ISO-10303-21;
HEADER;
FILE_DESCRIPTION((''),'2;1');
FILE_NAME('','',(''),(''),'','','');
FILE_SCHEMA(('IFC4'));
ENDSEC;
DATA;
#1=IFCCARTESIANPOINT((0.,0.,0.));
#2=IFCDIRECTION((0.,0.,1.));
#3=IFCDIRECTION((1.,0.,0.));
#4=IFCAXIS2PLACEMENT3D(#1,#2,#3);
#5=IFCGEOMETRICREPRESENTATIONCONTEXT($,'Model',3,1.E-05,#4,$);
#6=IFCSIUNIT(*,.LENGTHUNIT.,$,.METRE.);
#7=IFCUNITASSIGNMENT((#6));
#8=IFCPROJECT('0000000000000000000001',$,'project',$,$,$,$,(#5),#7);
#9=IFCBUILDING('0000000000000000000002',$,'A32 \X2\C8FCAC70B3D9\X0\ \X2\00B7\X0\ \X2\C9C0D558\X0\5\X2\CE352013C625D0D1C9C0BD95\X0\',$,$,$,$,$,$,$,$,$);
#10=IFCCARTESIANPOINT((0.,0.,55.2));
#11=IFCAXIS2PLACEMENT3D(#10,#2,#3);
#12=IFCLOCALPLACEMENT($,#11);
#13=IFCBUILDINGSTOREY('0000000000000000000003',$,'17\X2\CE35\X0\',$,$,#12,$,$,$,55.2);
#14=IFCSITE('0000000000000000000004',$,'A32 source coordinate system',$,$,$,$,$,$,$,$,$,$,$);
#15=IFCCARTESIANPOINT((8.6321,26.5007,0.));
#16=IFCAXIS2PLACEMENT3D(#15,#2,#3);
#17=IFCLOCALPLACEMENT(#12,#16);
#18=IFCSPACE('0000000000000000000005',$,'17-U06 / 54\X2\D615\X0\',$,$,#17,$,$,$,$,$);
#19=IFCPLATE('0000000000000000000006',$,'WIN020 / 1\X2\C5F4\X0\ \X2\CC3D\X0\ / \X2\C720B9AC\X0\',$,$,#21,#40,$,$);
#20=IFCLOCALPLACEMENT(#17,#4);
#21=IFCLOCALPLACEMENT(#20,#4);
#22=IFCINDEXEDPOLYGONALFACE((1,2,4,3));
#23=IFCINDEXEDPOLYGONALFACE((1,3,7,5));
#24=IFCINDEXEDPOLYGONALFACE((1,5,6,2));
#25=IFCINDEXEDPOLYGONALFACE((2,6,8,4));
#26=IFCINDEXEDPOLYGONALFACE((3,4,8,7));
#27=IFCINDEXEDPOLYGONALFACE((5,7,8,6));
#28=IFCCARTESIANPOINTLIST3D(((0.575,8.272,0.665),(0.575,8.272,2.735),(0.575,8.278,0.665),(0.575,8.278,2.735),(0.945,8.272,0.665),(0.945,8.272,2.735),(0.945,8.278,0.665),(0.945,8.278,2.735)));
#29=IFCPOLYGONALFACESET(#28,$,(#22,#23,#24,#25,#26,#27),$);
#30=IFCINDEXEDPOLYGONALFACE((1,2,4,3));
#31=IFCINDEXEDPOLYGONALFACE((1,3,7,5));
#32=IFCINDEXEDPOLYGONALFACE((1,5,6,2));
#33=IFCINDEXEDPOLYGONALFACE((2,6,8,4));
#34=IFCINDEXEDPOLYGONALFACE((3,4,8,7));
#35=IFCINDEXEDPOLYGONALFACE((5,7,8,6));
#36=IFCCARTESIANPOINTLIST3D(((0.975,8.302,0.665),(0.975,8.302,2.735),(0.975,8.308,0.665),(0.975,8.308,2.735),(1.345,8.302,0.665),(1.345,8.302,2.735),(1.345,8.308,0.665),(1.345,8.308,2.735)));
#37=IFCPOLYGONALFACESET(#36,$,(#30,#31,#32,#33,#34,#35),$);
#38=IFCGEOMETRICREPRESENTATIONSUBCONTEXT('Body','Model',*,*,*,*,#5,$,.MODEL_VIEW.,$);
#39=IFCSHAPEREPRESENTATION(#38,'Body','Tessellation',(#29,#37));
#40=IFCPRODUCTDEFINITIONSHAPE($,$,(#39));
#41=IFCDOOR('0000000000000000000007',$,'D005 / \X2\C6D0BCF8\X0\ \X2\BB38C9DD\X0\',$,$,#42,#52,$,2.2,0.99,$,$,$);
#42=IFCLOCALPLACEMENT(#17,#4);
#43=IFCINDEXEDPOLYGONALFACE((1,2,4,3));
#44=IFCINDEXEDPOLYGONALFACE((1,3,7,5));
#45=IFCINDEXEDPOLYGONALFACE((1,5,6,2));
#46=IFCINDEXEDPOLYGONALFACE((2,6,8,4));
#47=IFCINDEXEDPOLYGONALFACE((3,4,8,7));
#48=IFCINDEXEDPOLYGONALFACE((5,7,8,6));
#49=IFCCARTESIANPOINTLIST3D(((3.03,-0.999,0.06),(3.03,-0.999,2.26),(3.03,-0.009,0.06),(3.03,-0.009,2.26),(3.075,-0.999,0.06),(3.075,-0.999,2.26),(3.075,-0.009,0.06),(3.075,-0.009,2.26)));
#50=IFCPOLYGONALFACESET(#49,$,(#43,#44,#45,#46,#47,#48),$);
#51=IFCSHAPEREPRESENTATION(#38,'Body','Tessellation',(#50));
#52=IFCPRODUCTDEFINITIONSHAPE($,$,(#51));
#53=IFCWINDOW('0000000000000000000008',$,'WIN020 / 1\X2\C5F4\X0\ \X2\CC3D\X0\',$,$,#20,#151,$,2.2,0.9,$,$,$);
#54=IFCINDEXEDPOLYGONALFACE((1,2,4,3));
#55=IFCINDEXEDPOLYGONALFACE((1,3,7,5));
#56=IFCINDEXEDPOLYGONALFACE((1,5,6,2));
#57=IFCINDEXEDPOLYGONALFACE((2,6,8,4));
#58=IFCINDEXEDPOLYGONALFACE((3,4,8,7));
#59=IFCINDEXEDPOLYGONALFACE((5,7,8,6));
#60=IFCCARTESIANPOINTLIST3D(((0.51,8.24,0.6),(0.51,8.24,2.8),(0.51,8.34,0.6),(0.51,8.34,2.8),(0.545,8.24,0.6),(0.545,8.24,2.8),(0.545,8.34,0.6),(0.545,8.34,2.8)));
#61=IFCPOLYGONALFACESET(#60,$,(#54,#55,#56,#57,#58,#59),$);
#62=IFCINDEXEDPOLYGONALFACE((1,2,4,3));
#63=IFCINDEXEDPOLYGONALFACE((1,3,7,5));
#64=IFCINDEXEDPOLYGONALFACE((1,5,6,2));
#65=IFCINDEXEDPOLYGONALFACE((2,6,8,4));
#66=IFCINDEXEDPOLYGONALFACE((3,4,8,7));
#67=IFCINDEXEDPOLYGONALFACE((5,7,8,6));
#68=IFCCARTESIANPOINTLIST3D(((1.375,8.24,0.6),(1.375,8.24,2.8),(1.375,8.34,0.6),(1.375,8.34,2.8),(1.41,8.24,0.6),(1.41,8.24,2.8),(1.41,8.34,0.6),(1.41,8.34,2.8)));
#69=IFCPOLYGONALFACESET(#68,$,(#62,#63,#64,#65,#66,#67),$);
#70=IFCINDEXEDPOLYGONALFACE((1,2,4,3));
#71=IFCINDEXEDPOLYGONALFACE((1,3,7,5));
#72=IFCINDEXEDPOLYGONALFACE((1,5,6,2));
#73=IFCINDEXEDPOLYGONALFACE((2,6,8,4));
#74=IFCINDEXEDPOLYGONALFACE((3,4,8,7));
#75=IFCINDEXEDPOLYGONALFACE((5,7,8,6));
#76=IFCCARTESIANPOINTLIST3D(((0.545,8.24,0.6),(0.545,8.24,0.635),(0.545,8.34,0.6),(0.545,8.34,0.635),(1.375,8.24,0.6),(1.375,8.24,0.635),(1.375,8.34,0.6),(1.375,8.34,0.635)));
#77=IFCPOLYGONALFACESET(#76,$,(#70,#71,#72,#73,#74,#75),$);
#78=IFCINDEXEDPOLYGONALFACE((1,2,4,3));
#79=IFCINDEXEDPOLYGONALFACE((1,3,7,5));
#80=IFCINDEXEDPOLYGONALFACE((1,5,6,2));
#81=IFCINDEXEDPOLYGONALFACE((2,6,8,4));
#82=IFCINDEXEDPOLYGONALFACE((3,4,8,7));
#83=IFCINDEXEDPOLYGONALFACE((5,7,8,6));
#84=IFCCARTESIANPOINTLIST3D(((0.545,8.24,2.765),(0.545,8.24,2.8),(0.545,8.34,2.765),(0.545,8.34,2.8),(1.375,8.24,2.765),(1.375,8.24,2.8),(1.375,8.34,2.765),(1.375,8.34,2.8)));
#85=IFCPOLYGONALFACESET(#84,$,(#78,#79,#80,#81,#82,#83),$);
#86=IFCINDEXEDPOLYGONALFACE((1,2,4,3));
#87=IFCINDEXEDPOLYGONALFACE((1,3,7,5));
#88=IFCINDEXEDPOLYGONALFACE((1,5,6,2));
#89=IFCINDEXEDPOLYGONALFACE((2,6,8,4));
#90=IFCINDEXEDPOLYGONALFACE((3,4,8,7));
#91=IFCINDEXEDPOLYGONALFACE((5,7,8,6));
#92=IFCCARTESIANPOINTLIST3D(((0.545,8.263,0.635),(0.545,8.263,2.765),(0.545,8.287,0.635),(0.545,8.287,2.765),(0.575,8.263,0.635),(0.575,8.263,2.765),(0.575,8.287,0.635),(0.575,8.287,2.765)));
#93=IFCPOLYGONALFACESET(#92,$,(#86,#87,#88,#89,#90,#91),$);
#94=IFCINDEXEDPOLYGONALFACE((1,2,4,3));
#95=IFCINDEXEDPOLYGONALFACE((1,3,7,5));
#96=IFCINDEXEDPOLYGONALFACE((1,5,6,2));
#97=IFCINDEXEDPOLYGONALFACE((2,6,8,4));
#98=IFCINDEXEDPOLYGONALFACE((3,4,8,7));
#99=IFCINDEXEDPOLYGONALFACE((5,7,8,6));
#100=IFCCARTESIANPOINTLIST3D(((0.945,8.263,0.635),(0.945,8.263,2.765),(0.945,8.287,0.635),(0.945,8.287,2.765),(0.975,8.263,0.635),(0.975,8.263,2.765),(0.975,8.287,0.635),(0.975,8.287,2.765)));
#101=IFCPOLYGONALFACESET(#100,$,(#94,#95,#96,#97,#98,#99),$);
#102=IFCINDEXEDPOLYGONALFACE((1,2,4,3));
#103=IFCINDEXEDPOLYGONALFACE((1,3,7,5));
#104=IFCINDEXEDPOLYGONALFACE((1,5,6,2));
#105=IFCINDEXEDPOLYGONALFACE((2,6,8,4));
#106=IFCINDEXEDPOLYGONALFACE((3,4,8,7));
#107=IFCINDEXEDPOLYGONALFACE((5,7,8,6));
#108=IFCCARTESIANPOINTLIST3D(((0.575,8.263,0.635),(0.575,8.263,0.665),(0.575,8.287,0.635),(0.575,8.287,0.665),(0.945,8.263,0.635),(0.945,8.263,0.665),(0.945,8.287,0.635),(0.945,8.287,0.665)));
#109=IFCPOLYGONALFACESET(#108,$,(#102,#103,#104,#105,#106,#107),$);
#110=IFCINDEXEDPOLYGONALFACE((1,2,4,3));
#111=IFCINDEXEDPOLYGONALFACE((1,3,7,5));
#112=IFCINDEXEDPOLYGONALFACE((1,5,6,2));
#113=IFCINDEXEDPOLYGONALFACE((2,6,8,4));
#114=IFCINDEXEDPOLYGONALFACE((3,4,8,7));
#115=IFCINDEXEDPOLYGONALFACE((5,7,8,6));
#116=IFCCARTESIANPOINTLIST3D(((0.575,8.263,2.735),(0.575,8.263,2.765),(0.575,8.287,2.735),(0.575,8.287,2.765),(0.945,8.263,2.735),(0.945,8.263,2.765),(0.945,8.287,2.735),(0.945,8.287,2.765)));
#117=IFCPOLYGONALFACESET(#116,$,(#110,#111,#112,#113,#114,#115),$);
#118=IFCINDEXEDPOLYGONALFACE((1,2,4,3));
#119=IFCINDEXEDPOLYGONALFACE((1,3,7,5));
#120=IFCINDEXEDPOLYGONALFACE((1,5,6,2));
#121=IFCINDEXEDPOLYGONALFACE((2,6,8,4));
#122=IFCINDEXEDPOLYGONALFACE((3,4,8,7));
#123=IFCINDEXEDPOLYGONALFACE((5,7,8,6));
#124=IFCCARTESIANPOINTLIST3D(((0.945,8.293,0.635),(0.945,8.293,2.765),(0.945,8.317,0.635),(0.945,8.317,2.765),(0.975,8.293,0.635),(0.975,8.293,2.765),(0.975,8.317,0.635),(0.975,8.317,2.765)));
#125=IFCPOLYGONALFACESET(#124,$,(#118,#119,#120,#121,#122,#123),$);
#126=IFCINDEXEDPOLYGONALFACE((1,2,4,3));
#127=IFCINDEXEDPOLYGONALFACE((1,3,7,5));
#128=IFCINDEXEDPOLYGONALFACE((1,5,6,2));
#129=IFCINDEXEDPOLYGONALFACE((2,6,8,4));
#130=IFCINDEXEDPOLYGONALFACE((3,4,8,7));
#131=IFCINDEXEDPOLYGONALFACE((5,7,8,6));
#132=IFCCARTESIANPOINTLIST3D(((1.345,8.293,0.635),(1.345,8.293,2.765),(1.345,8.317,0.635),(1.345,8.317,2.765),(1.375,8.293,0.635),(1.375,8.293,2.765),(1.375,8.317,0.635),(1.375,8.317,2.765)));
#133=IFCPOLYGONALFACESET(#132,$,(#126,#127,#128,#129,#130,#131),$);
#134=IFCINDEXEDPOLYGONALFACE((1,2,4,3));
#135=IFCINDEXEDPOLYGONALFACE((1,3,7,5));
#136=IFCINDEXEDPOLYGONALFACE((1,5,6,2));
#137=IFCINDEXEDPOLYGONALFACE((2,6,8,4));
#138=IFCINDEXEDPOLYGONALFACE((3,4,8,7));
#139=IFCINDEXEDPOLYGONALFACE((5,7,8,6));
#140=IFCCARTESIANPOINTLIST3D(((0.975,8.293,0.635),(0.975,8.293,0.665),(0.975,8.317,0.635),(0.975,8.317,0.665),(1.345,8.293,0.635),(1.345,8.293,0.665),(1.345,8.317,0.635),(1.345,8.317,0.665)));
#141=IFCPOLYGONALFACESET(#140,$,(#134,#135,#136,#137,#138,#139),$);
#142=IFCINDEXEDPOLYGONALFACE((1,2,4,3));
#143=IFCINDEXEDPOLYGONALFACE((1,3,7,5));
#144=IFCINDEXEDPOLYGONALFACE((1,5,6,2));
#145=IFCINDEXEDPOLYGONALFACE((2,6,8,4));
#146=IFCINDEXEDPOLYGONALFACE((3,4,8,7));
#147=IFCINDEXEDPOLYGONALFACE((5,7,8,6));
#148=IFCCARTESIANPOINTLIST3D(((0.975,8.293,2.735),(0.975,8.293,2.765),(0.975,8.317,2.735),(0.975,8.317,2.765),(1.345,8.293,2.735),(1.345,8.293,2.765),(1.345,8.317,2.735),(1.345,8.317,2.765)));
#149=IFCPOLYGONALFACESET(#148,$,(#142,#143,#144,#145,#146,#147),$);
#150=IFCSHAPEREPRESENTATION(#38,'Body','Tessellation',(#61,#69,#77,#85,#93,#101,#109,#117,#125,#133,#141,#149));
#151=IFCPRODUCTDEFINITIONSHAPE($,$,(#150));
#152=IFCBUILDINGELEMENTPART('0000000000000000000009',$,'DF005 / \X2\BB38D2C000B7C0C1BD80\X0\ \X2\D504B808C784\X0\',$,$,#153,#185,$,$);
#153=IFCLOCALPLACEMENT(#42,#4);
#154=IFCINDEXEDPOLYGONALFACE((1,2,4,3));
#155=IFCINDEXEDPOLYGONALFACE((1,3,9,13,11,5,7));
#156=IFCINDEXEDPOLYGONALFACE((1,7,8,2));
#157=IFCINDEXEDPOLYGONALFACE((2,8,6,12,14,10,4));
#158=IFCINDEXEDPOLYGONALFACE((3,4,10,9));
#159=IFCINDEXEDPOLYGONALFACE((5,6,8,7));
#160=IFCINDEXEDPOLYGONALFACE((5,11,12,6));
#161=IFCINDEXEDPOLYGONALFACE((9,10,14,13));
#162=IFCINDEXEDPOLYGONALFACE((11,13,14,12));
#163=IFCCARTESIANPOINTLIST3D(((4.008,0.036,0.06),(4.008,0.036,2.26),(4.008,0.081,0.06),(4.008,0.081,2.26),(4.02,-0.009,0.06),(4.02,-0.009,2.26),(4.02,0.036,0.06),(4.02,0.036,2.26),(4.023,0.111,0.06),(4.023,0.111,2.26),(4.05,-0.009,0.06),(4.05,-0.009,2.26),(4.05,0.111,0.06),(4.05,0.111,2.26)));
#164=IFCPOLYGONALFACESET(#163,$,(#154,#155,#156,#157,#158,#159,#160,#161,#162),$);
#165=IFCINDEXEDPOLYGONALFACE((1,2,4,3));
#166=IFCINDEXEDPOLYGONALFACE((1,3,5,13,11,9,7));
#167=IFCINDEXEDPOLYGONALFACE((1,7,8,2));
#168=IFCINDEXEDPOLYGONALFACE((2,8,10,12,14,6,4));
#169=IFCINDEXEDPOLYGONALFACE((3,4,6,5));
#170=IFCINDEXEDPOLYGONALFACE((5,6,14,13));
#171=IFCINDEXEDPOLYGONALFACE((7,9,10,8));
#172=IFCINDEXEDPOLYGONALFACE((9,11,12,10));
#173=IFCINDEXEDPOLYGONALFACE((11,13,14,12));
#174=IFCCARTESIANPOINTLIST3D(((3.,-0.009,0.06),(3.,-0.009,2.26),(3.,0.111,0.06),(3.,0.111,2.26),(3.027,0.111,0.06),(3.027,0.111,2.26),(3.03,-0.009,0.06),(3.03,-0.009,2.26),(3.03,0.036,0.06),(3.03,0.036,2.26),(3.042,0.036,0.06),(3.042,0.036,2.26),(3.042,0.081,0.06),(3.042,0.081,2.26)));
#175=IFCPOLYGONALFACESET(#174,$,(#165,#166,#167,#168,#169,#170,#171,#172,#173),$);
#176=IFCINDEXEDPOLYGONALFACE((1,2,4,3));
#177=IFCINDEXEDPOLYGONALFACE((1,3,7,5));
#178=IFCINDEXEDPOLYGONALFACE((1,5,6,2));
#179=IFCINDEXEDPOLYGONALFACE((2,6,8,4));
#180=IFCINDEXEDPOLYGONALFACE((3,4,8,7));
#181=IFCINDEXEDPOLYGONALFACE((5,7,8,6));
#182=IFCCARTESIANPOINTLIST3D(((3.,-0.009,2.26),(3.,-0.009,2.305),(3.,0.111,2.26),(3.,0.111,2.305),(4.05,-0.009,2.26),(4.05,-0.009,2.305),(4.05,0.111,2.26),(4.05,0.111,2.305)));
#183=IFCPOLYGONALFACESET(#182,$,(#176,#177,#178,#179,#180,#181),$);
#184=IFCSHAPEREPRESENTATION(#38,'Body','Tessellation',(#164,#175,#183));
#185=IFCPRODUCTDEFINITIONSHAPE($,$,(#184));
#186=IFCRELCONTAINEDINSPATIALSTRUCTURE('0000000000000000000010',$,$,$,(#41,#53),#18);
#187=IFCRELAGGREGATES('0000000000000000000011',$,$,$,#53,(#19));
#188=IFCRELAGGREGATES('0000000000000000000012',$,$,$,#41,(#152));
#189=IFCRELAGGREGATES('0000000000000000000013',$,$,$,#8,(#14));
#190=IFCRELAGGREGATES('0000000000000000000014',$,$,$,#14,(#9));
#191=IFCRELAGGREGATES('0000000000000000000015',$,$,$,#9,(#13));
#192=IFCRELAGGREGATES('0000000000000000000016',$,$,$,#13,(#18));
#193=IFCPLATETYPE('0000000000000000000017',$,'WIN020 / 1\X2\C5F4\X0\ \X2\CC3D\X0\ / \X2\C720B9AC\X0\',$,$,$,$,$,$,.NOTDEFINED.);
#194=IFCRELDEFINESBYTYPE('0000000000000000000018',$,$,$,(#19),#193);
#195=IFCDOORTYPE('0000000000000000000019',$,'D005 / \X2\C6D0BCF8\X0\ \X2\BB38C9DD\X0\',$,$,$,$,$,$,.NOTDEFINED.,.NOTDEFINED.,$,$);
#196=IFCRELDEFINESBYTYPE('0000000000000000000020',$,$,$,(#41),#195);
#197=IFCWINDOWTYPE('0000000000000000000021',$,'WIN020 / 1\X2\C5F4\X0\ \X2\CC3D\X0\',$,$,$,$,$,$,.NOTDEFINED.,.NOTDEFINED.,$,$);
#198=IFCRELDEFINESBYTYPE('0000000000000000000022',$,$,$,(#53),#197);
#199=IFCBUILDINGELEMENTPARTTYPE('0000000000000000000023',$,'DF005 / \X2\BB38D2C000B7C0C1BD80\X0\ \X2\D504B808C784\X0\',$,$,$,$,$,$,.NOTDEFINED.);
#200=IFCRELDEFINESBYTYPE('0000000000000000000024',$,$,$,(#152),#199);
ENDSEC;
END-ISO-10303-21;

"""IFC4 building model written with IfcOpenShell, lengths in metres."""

from ifc_helpers import new_model, si_unit, frame, origin, origin_with_axes, place, context, subcontext, project, spatial, polyline, outline, extrude, source, transform, mapped, type_object, type_shapes, element, aggregate, save


model = new_model("IFC4")

# Units and contexts
model_context = context("Model", 3, precision=1e-05, world=origin_with_axes())
body_context = subcontext(model_context, "Body", "Model", "MODEL_VIEW")
ifc_project = project(units=[si_unit("LENGTHUNIT", "METRE")], contexts=[model_context])

# Plate
storey_placement = place(None, frame((0.0, 0.0, 55.2), z_axis=(0.0, 0.0, 1.0), x_axis=(1.0, 0.0, 0.0)))
space_1_placement = place(storey_placement, frame((8.6321, 26.5007, 0.0), z_axis=(0.0, 0.0, 1.0), x_axis=(1.0, 0.0, 0.0)))
plate_type_1 = type_object("IfcPlateType", Name="WIN020 / 1열 창 / 유리", PredefinedType="NOTDEFINED")
shared_shape_1 = source(origin(), body_context, "Body", "SweptSolid", [
    extrude(outline(polyline([(0.575, 8.272), (0.575, 8.278), (0.945, 8.278), (0.945, 8.272), (0.575, 8.272)])), frame((0.0, 0.0, 0.665)), (0.0, 0.0, 1.0), 2.07),
    extrude(outline(polyline([(0.975, 8.302), (0.975, 8.308), (1.345, 8.308), (1.345, 8.302), (0.975, 8.302)])), frame((0.0, 0.0, 0.665)), (0.0, 0.0, 1.0), 2.07),
])
type_shapes(plate_type_1, [shared_shape_1])
window_1_placement = place(space_1_placement, origin_with_axes())
plate_1_placement = place(window_1_placement, origin_with_axes())
plate_1 = element("IfcPlate", 1, at=plate_1_placement, type_object=plate_type_1, Name="WIN020 / 1열 창 / 유리", context=body_context, shape_type="MappedRepresentation", body=[
    mapped(shared_shape_1, transform((0.0, 0.0, 0.0), scale=1.0)),
])

# Site, building, storey, space
site = spatial("IfcSite", under=ifc_project, Name="A32 source coordinate system")
building = spatial("IfcBuilding", under=site, Name="A32 주거동 · 지하5층–옥탑지붕")
storey = spatial("IfcBuildingStorey", under=building, at=storey_placement, Name="17층", Elevation=55.2)
space_1 = spatial("IfcSpace", under=storey, at=space_1_placement, Name="17-U06 / 54형")

# Door
door_type_1 = type_object("IfcDoorType", Name="D005 / 원본 문짝", OperationType="NOTDEFINED", PredefinedType="NOTDEFINED")
shared_shape_2 = source(origin(), body_context, "Body", "SweptSolid", [
    extrude(outline(polyline([(3.075, -0.999), (3.03, -0.999), (3.03, -0.009), (3.075, -0.009), (3.075, -0.999)])), frame((0.0, 0.0, 0.06)), (0.0, 0.0, 1.0), 2.2),
])
type_shapes(door_type_1, [shared_shape_2])
door_1_placement = place(space_1_placement, origin_with_axes())
door_1 = element("IfcDoor", 2, at=door_1_placement, inside=space_1, type_object=door_type_1, Name="D005 / 원본 문짝", OverallHeight=2.2, OverallWidth=0.99, context=body_context, shape_type="MappedRepresentation", body=[
    mapped(shared_shape_2, transform((0.0, 0.0, 0.0), scale=1.0)),
])

# Window
window_type_1 = type_object("IfcWindowType", Name="WIN020 / 1열 창", PartitioningType="NOTDEFINED", PredefinedType="NOTDEFINED")
shared_shape_3 = source(origin(), body_context, "Body", "SweptSolid", [
    extrude(outline(polyline([(0.51, 8.24), (0.51, 8.34), (0.545, 8.34), (0.545, 8.24), (0.51, 8.24)])), frame((0.0, 0.0, 0.6)), (0.0, 0.0, 1.0), 2.2),
    extrude(outline(polyline([(1.375, 8.24), (1.375, 8.34), (1.41, 8.34), (1.41, 8.24), (1.375, 8.24)])), frame((0.0, 0.0, 0.6)), (0.0, 0.0, 1.0), 2.2),
    extrude(outline(polyline([(0.545, 8.24), (0.545, 8.34), (1.375, 8.34), (1.375, 8.24), (0.545, 8.24)])), frame((0.0, 0.0, 0.6)), (0.0, 0.0, 1.0), 0.035),
    extrude(outline(polyline([(0.545, 8.24), (0.545, 8.34), (1.375, 8.34), (1.375, 8.24), (0.545, 8.24)])), frame((0.0, 0.0, 2.765)), (0.0, 0.0, 1.0), 0.035),
    extrude(outline(polyline([(0.545, 8.263), (0.545, 8.287), (0.575, 8.287), (0.575, 8.263), (0.545, 8.263)])), frame((0.0, 0.0, 0.635)), (0.0, 0.0, 1.0), 2.13),
    extrude(outline(polyline([(0.945, 8.263), (0.945, 8.287), (0.975, 8.287), (0.975, 8.263), (0.945, 8.263)])), frame((0.0, 0.0, 0.635)), (0.0, 0.0, 1.0), 2.13),
    extrude(outline(polyline([(0.575, 8.263), (0.575, 8.287), (0.945, 8.287), (0.945, 8.263), (0.575, 8.263)])), frame((0.0, 0.0, 0.635)), (0.0, 0.0, 1.0), 0.03),
    extrude(outline(polyline([(0.575, 8.263), (0.575, 8.287), (0.945, 8.287), (0.945, 8.263), (0.575, 8.263)])), frame((0.0, 0.0, 2.735)), (0.0, 0.0, 1.0), 0.03),
    extrude(outline(polyline([(0.945, 8.293), (0.945, 8.317), (0.975, 8.317), (0.975, 8.293), (0.945, 8.293)])), frame((0.0, 0.0, 0.635)), (0.0, 0.0, 1.0), 2.13),
    extrude(outline(polyline([(1.345, 8.293), (1.345, 8.317), (1.375, 8.317), (1.375, 8.293), (1.345, 8.293)])), frame((0.0, 0.0, 0.635)), (0.0, 0.0, 1.0), 2.13),
    extrude(outline(polyline([(0.975, 8.293), (0.975, 8.317), (1.345, 8.317), (1.345, 8.293), (0.975, 8.293)])), frame((0.0, 0.0, 0.635)), (0.0, 0.0, 1.0), 0.03),
    extrude(outline(polyline([(0.975, 8.293), (0.975, 8.317), (1.345, 8.317), (1.345, 8.293), (0.975, 8.293)])), frame((0.0, 0.0, 2.735)), (0.0, 0.0, 1.0), 0.03),
])
type_shapes(window_type_1, [shared_shape_3])
window_1 = element("IfcWindow", 3, at=window_1_placement, inside=space_1, type_object=window_type_1, Name="WIN020 / 1열 창", OverallHeight=2.2, OverallWidth=0.9, context=body_context, shape_type="MappedRepresentation", body=[
    mapped(shared_shape_3, transform((0.0, 0.0, 0.0), scale=1.0)),
])
aggregate(window_1, [plate_1])

# Building element part
building_element_part_type_1 = type_object("IfcBuildingElementPartType", Name="DF005 / 문틀·상부 프레임", PredefinedType="NOTDEFINED")
shared_shape_4 = source(origin(), body_context, "Body", "SweptSolid", [
    extrude(outline(polyline([(4.02, -0.009), (4.02, 0.036), (4.008, 0.036), (4.008, 0.081), (4.023, 0.111), (4.05, 0.111), (4.05, -0.009), (4.02, -0.009)])), frame((0.0, 0.0, 0.06)), (0.0, 0.0, 1.0), 2.2),
    extrude(outline(polyline([(3.0, 0.111), (3.027, 0.111), (3.042, 0.081), (3.042, 0.036), (3.03, 0.036), (3.03, -0.009), (3.0, -0.009), (3.0, 0.111)])), frame((0.0, 0.0, 0.06)), (0.0, 0.0, 1.0), 2.2),
    extrude(outline(polyline([(3.0, -0.009), (3.0, 0.111), (4.05, 0.111), (4.05, -0.009), (3.0, -0.009)])), frame((0.0, 0.0, 2.26)), (0.0, 0.0, 1.0), 0.045),
])
type_shapes(building_element_part_type_1, [shared_shape_4])
building_element_part_1_placement = place(door_1_placement, origin_with_axes())
building_element_part_1 = element("IfcBuildingElementPart", 4, at=building_element_part_1_placement, type_object=building_element_part_type_1, Name="DF005 / 문틀·상부 프레임", context=body_context, shape_type="MappedRepresentation", body=[
    mapped(shared_shape_4, transform((0.0, 0.0, 0.0), scale=1.0)),
])
aggregate(door_1, [building_element_part_1])

save(model, "model.ifc")
